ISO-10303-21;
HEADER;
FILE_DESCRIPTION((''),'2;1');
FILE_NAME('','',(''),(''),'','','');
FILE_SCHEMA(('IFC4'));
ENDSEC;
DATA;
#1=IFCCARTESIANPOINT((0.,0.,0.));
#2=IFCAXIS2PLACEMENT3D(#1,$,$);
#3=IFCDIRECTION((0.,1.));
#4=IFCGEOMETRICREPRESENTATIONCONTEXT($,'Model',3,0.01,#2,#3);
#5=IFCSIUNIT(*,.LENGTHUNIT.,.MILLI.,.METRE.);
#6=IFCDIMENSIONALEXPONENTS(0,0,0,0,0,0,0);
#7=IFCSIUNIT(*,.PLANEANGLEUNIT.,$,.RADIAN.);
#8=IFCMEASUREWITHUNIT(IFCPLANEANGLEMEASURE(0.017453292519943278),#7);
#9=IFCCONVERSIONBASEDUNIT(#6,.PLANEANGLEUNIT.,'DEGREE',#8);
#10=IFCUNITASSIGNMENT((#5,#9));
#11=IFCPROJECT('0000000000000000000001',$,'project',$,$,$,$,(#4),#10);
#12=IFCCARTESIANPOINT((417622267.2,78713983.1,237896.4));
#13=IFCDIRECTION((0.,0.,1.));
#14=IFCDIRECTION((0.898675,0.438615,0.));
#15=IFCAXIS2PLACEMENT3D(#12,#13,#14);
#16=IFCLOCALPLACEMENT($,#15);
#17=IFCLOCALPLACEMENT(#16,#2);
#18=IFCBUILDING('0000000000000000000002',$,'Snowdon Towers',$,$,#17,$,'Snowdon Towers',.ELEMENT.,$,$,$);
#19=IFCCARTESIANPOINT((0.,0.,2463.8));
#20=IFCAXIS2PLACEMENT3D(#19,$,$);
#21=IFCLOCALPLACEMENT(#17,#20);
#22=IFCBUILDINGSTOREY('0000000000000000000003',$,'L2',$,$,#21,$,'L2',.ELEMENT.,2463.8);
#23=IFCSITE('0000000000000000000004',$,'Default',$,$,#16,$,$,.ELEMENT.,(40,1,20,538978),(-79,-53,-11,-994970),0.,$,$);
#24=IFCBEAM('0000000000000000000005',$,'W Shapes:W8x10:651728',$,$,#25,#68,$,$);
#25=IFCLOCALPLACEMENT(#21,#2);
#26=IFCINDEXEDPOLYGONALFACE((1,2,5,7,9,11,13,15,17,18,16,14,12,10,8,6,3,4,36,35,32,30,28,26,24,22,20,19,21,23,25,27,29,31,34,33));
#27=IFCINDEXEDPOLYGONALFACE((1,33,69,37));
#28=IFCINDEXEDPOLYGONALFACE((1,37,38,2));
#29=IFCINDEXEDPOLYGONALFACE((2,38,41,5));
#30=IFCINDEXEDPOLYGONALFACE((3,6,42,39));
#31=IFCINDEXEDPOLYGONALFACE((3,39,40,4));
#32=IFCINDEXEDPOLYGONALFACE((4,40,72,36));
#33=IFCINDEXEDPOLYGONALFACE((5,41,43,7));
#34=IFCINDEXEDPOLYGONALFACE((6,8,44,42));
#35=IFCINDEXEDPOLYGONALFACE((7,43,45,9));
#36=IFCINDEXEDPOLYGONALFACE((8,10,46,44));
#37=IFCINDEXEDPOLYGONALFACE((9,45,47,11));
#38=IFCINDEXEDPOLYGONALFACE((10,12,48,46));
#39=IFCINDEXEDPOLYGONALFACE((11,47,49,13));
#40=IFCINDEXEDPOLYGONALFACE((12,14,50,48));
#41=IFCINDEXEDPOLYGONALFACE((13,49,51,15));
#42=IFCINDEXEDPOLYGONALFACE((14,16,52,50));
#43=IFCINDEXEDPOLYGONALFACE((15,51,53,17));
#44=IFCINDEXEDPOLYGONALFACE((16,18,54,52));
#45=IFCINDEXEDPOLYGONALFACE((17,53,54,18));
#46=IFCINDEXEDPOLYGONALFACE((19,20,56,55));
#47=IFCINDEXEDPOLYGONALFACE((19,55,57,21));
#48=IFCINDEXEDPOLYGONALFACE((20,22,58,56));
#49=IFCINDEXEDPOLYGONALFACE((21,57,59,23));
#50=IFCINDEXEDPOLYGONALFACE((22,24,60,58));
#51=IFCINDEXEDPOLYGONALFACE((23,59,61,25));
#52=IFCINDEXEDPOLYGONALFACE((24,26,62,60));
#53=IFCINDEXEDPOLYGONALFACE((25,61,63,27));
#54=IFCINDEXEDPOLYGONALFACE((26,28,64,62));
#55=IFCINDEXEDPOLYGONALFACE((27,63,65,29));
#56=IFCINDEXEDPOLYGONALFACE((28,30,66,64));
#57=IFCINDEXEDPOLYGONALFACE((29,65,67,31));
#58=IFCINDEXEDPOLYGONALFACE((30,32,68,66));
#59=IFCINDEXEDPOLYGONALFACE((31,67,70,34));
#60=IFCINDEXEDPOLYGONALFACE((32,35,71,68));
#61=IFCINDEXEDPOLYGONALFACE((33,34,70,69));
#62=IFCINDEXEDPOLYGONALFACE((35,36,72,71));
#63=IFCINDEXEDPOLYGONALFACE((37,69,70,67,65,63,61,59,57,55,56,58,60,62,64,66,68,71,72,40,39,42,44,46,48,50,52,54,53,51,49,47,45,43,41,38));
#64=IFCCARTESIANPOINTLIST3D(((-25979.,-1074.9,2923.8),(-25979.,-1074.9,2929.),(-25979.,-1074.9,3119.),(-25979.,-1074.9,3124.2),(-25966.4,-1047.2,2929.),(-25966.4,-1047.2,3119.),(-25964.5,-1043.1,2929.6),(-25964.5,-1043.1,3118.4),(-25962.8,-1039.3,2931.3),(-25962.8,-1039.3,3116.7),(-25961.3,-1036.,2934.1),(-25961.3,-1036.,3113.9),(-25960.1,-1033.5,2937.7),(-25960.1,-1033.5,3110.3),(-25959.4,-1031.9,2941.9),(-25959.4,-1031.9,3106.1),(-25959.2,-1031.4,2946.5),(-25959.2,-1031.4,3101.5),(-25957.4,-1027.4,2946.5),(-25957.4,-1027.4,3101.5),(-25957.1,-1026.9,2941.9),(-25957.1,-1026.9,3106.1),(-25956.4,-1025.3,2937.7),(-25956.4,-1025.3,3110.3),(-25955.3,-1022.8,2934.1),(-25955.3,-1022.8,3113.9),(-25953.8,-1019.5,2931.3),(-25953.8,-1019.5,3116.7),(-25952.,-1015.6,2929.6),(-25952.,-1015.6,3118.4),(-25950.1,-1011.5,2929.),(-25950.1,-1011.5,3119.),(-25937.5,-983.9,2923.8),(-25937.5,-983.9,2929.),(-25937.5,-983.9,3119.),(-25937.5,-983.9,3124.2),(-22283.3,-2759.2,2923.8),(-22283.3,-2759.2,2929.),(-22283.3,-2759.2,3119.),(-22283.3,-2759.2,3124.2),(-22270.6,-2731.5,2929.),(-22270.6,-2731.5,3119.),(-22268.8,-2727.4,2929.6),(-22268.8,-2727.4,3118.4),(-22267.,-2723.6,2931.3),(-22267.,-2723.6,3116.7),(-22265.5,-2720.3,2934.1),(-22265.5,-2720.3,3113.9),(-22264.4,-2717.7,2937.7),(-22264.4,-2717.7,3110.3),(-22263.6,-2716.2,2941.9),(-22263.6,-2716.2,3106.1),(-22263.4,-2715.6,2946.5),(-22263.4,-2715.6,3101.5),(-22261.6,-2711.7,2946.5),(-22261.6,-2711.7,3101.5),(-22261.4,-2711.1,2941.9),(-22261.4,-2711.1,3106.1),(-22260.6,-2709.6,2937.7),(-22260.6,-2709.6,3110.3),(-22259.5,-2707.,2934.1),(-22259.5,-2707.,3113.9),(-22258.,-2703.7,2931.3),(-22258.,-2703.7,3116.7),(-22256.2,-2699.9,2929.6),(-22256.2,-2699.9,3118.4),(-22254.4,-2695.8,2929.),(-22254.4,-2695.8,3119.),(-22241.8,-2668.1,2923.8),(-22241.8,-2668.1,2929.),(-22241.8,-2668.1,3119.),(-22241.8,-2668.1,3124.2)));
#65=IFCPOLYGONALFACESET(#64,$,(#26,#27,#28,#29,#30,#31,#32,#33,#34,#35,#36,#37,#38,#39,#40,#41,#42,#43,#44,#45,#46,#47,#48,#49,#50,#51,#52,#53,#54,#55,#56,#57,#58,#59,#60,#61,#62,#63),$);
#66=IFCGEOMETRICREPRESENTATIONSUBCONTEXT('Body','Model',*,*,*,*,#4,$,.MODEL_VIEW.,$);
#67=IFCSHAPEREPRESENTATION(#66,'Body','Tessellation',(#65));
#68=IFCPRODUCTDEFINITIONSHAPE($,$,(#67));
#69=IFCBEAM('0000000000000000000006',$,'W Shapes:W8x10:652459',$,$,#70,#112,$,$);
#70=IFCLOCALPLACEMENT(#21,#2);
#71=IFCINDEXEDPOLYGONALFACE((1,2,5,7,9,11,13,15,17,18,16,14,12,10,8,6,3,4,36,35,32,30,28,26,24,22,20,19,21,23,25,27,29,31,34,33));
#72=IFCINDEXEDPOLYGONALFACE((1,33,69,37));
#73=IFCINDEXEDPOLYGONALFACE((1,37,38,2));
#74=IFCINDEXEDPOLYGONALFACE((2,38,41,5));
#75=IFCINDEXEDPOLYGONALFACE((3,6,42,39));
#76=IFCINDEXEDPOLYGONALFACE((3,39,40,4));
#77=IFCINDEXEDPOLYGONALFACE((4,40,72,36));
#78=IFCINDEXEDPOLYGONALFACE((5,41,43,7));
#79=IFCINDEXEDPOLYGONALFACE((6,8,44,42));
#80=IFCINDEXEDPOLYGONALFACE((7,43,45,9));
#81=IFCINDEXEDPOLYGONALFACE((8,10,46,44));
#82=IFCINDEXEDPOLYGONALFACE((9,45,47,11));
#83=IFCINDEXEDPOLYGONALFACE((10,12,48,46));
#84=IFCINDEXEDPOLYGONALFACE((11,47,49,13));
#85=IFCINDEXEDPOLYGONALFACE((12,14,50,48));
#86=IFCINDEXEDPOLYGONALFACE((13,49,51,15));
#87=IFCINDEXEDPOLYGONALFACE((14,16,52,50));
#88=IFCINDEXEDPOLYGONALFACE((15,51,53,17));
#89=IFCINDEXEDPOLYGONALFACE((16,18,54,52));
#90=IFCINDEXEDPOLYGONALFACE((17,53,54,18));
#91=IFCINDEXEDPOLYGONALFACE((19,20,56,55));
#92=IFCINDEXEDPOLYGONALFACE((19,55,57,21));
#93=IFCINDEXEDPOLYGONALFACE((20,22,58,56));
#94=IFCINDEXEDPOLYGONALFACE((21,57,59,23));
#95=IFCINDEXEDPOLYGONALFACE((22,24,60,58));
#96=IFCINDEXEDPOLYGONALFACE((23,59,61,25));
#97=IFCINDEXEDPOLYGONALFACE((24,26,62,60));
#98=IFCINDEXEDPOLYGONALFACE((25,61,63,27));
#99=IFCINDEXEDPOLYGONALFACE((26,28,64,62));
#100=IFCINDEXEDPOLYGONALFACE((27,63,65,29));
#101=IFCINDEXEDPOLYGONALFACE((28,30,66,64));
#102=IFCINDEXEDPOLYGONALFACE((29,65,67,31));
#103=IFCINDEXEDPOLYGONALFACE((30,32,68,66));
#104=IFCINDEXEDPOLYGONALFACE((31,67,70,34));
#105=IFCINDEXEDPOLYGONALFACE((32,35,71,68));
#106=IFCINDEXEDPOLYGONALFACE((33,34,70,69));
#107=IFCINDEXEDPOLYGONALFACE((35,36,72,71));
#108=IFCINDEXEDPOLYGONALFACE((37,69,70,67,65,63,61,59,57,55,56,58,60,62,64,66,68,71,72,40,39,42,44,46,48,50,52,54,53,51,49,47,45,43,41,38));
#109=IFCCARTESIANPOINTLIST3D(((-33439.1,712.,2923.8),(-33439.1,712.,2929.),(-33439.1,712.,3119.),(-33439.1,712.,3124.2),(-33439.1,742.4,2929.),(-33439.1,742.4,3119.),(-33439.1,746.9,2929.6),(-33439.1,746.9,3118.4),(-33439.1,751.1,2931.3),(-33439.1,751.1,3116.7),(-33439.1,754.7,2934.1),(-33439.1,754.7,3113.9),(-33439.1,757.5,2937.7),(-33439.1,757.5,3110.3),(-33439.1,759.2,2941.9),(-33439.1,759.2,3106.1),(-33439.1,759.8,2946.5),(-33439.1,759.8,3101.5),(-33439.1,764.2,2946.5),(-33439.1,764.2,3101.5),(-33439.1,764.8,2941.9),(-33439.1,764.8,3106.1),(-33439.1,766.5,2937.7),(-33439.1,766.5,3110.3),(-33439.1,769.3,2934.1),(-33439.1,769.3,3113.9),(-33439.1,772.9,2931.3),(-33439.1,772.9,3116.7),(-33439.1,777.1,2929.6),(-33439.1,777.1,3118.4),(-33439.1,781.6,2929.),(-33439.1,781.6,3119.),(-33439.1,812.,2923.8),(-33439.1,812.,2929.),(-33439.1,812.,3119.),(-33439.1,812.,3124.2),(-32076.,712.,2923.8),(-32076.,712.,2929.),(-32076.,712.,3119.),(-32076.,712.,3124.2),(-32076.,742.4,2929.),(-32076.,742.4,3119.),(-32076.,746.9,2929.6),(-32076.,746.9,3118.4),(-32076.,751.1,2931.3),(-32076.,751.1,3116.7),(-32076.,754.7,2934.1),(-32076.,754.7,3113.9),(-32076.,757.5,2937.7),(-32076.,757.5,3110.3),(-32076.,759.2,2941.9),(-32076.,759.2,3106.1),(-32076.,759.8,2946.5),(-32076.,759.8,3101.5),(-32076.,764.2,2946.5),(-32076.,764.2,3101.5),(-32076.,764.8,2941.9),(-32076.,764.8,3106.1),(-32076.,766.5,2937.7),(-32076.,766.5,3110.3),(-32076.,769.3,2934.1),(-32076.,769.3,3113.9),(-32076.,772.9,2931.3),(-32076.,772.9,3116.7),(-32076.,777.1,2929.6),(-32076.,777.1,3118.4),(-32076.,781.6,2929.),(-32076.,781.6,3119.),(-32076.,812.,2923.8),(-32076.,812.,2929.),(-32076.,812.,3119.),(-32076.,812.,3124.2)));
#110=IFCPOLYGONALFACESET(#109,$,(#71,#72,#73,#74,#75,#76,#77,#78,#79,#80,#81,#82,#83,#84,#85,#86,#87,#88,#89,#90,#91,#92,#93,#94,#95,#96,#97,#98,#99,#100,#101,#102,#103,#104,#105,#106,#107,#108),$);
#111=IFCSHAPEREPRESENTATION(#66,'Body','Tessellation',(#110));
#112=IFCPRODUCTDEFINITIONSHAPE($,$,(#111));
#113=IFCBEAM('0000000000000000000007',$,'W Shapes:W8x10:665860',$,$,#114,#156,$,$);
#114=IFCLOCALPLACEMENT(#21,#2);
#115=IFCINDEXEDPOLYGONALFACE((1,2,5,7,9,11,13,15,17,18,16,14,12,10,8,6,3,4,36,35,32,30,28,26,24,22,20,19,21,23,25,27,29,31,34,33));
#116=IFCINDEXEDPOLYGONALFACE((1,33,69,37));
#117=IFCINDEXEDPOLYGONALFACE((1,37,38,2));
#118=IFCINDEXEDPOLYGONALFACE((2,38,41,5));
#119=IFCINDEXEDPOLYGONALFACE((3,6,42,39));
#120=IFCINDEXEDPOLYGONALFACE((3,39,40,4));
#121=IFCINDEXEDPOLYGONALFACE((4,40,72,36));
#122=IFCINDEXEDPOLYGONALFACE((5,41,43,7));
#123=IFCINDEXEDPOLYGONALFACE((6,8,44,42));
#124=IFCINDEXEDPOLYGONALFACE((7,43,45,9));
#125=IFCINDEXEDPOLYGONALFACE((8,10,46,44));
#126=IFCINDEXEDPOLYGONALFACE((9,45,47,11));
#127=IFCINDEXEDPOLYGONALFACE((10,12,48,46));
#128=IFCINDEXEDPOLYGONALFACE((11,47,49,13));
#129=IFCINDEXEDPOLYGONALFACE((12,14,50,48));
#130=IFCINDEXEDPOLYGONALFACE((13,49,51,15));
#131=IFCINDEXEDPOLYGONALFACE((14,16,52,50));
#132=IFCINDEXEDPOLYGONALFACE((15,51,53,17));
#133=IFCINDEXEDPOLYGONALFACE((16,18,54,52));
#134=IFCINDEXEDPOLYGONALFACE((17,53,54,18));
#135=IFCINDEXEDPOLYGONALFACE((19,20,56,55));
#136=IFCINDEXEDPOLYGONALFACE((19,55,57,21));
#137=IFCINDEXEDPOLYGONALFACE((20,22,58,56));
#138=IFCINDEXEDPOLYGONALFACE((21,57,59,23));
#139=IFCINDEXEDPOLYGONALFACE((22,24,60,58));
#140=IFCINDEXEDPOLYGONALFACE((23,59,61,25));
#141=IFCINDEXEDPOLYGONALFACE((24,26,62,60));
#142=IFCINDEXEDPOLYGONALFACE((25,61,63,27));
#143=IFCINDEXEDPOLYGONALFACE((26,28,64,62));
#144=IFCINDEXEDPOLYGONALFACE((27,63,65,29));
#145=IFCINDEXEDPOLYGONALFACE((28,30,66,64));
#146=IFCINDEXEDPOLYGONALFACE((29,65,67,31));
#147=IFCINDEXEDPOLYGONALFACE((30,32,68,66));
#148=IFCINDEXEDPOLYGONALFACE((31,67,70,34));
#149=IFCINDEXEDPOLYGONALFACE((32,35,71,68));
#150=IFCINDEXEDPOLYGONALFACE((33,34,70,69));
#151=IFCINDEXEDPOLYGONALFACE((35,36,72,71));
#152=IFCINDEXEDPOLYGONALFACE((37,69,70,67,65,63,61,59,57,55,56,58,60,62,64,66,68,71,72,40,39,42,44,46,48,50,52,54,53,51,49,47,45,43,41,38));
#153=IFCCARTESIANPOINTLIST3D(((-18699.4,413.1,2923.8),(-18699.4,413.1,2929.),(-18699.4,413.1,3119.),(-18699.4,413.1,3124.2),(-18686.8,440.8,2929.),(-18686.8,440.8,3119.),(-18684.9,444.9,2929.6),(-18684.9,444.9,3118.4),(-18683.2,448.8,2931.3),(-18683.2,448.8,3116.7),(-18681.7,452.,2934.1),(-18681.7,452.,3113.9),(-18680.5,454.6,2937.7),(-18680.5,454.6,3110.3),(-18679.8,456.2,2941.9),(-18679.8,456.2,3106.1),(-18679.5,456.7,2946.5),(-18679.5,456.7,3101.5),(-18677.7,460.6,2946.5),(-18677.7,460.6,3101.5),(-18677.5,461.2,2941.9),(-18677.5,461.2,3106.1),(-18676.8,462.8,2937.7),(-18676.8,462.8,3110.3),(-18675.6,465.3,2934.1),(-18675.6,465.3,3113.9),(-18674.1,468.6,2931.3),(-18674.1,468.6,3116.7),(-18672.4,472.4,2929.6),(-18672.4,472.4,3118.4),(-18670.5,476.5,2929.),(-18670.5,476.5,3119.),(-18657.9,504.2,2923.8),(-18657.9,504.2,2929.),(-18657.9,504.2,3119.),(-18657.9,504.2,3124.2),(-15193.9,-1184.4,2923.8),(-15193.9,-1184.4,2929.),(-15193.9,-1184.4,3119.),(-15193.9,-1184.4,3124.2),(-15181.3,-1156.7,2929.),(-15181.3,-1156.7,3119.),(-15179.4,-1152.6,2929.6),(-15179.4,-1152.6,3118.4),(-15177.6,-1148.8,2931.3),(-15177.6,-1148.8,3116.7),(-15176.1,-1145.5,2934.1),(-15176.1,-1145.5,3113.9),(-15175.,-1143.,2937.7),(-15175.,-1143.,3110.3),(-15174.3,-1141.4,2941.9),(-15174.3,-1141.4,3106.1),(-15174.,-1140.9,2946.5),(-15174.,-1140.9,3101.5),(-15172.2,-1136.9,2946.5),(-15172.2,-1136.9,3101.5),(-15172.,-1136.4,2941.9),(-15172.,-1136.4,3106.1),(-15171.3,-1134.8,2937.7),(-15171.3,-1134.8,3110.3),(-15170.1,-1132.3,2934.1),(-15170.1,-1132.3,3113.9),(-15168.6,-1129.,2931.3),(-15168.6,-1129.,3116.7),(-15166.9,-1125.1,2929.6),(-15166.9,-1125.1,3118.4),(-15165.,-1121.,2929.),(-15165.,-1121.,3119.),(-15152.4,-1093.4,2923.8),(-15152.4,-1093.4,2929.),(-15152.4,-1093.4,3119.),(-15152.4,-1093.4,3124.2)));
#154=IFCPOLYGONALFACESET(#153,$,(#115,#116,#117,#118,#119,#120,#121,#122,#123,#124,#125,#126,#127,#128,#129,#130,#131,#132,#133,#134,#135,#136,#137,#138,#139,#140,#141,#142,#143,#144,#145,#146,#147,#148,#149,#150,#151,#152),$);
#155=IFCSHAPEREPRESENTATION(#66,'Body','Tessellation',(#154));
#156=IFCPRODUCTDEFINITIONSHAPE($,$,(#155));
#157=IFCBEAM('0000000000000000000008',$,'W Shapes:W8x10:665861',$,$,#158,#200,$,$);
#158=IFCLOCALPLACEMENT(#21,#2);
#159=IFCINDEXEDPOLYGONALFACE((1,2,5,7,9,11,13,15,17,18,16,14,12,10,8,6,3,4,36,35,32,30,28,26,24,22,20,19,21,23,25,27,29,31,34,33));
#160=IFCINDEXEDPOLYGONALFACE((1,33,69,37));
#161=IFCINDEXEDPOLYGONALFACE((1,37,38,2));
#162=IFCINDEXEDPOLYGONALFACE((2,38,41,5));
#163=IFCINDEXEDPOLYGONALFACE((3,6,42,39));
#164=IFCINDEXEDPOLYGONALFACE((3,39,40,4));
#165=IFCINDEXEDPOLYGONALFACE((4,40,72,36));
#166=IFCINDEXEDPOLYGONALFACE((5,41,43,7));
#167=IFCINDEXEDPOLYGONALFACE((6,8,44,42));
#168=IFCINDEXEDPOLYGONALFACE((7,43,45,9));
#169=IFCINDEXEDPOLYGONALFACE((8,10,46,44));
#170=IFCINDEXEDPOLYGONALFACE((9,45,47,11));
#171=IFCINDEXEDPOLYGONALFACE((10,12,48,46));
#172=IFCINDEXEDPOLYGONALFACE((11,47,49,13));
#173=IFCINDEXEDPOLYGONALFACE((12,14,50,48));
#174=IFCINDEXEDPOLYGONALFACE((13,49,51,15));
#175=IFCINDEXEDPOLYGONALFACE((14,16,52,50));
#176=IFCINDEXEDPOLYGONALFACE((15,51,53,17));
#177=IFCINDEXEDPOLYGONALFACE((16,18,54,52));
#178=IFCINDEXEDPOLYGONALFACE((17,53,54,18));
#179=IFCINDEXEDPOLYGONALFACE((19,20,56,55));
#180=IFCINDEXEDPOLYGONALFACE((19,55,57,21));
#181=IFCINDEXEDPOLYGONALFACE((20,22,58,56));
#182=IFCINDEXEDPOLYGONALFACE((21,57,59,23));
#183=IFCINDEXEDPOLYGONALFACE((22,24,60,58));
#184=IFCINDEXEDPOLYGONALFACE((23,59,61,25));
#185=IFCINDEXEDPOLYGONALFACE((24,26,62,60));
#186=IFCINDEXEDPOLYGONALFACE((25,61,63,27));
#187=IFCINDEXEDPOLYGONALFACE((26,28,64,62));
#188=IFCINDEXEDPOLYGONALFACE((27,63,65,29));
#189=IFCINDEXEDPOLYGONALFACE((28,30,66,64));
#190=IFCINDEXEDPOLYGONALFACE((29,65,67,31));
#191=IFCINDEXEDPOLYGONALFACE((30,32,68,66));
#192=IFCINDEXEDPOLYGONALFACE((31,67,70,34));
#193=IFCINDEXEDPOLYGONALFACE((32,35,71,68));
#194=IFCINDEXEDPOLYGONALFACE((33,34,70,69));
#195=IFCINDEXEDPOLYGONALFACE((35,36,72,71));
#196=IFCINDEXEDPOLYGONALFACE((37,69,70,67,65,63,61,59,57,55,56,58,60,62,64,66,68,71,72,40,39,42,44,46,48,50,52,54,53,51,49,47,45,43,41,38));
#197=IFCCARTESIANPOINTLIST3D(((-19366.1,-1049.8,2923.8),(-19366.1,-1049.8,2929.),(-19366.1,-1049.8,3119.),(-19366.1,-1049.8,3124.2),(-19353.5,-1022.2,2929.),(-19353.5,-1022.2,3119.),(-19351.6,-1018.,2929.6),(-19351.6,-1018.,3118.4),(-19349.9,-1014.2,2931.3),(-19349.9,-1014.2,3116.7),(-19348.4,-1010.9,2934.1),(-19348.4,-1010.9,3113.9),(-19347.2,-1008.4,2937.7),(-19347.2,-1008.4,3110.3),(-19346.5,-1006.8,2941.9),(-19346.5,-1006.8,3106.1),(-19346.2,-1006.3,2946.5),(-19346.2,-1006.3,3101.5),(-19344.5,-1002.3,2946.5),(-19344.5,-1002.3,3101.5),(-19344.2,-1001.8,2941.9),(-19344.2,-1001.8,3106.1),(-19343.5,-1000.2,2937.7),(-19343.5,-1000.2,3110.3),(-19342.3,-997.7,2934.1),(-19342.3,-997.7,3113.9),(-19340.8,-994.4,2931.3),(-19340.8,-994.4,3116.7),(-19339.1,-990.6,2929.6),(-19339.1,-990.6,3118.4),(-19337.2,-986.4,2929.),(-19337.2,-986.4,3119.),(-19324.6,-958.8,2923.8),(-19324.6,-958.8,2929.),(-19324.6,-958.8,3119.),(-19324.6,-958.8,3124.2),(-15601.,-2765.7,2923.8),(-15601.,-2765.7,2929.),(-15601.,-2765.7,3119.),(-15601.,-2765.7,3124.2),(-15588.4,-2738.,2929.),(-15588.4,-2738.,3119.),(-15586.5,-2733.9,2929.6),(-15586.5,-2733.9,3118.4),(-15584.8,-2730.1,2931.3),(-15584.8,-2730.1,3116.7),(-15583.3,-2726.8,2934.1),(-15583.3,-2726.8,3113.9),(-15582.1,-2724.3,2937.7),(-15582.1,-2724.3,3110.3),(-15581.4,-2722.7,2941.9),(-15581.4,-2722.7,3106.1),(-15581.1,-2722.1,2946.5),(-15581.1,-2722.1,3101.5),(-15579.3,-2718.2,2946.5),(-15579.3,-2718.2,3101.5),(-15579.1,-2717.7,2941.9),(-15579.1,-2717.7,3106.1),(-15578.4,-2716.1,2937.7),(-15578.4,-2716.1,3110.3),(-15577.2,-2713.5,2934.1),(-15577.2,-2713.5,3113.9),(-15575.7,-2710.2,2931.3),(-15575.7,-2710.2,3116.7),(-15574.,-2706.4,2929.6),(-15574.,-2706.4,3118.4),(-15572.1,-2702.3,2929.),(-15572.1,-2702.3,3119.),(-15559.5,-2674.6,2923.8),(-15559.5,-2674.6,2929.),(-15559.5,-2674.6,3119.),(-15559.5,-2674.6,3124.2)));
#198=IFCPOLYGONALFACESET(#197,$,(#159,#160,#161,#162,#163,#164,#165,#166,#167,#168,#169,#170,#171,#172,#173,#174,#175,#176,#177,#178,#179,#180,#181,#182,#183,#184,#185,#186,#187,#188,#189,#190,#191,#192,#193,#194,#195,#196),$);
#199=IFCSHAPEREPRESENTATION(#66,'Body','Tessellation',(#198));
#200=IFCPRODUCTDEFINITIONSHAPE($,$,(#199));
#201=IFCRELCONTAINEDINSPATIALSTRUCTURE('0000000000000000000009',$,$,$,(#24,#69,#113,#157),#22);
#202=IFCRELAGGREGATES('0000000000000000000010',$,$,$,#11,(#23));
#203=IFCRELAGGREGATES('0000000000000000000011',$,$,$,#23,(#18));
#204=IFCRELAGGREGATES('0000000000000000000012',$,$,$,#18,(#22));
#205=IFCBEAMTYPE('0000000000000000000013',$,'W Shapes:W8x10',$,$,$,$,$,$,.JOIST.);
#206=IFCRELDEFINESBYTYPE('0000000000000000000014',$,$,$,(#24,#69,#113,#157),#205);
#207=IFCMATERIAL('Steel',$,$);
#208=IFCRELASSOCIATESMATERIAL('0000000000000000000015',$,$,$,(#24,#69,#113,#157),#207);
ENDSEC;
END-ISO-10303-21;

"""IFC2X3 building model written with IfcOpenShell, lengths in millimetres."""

from ifc_helpers import new_model, entity, si_unit, converted_unit, direction, frame, frame_2d, origin, place, context, subcontext, project, spatial, i_section, extrude, material, type_object, element, save


model = new_model("IFC2X3")

# Units and contexts
model_context = context("Model", 3, precision=0.01, world=origin(), true_north=direction((0.0, 1.0)))
body_context = subcontext(model_context, "Body", "Model", "MODEL_VIEW")
ifc_project = project(units=[si_unit("LENGTHUNIT", "METRE", prefix="MILLI"), converted_unit("PLANEANGLEUNIT", "DEGREE", entity("IfcPlaneAngleMeasure", 0.017453292519943278), si_unit("PLANEANGLEUNIT", "RADIAN"), dimensions=[0, 0, 0, 0, 0, 0, 0])], contexts=[model_context])

# Site, building, storey
site_placement = place(None, frame((417622267.2, 78713983.1, 237896.4), z_axis=(0.0, 0.0, 1.0), x_axis=(0.898675, 0.438615, 0.0)))
site = spatial("IfcSite", under=ifc_project, at=site_placement, Name="Default", CompositionType="ELEMENT", RefLatitude=(40, 1, 20, 538978), RefLongitude=(-79, -53, -11, -994970), RefElevation=0.0)
building_placement = place(site_placement, origin())
building = spatial("IfcBuilding", under=site, at=building_placement, Name="Snowdon Towers", LongName="Snowdon Towers", CompositionType="ELEMENT")
storey_placement = place(building_placement, frame((0.0, 0.0, 2463.8)))
storey = spatial("IfcBuildingStorey", under=building, at=storey_placement, Name="L2", LongName="L2", CompositionType="ELEMENT", Elevation=2463.8)

# Beams
ifc_material = material(Name="Steel")
beam_type_1 = type_object("IfcBeamType", Name="W Shapes:W8x10", PredefinedType="JOIST")
beam_1_placement = place(storey_placement, frame((-26086.6, -970.9, 3124.2), z_axis=(0.0, 0.0, 1.0), x_axis=(0.909961, -0.414693, 0.0)))
element("IfcBeam", 1, at=beam_1_placement, inside=storey, type_object=beam_type_1, material=ifc_material, Name="W Shapes:W8x10:651728", context=body_context, shape_type="SweptSolid", body=[
    extrude(i_section(OverallWidth=100.1, OverallDepth=200.4, WebThickness=4.3, FlangeThickness=5.2, FilletRadius=17.5, at=frame_2d((0.0, 0.0), x_axis=(0.0, 1.0))), frame((141.0, 0.0, -100.2), z_axis=(1.0, 0.0, 0.0), x_axis=(0.0, 0.0, -1.0)), (0.0, 0.0, 1.0), 4061.5),
])
beam_2_placement = place(storey_placement, frame((-33832.8, 762.0, 3124.2)))
element("IfcBeam", 2, at=beam_2_placement, inside=storey, type_object=beam_type_1, material=ifc_material, Name="W Shapes:W8x10:652459", context=body_context, shape_type="SweptSolid", body=[
    extrude(i_section(OverallWidth=100.1, OverallDepth=200.4, WebThickness=4.3, FlangeThickness=5.2, FilletRadius=17.5, at=frame_2d((0.0, 0.0), x_axis=(0.0, 1.0))), frame((393.7, 0.0, -100.2), z_axis=(1.0, 0.0, 0.0), x_axis=(0.0, 0.0, -1.0)), (0.0, 0.0, 1.0), 1363.1),
])
beam_3_placement = place(storey_placement, frame((-18806.9, 517.1, 3124.2), z_axis=(0.0, 0.0, 1.0), x_axis=(0.909961, -0.414693, 0.0)))
element("IfcBeam", 3, at=beam_3_placement, inside=storey, type_object=beam_type_1, material=ifc_material, Name="W Shapes:W8x10:665860", context=body_context, shape_type="SweptSolid", body=[
    extrude(i_section(OverallWidth=100.1, OverallDepth=200.4, WebThickness=4.3, FlangeThickness=5.2, FilletRadius=17.5, at=frame_2d((0.0, 0.0), x_axis=(0.0, 1.0))), frame((141.0, 0.0, -100.2), z_axis=(1.0, 0.0, 0.0), x_axis=(0.0, 0.0, -1.0)), (0.0, 0.0, 1.0), 3852.4),
])
beam_4_placement = place(storey_placement, frame((-19473.6, -945.8, 3124.2), z_axis=(0.0, 0.0, 1.0), x_axis=(0.909961, -0.414693, 0.0)))
element("IfcBeam", 4, at=beam_4_placement, inside=storey, type_object=beam_type_1, material=ifc_material, Name="W Shapes:W8x10:665861", context=body_context, shape_type="SweptSolid", body=[
    extrude(i_section(OverallWidth=100.1, OverallDepth=200.4, WebThickness=4.3, FlangeThickness=5.2, FilletRadius=17.5, at=frame_2d((0.0, 0.0), x_axis=(0.0, 1.0))), frame((141.0, 0.0, -100.2), z_axis=(1.0, 0.0, 0.0), x_axis=(0.0, 0.0, -1.0)), (0.0, 0.0, 1.0), 4137.7),
])

save(model, "model.ifc")
